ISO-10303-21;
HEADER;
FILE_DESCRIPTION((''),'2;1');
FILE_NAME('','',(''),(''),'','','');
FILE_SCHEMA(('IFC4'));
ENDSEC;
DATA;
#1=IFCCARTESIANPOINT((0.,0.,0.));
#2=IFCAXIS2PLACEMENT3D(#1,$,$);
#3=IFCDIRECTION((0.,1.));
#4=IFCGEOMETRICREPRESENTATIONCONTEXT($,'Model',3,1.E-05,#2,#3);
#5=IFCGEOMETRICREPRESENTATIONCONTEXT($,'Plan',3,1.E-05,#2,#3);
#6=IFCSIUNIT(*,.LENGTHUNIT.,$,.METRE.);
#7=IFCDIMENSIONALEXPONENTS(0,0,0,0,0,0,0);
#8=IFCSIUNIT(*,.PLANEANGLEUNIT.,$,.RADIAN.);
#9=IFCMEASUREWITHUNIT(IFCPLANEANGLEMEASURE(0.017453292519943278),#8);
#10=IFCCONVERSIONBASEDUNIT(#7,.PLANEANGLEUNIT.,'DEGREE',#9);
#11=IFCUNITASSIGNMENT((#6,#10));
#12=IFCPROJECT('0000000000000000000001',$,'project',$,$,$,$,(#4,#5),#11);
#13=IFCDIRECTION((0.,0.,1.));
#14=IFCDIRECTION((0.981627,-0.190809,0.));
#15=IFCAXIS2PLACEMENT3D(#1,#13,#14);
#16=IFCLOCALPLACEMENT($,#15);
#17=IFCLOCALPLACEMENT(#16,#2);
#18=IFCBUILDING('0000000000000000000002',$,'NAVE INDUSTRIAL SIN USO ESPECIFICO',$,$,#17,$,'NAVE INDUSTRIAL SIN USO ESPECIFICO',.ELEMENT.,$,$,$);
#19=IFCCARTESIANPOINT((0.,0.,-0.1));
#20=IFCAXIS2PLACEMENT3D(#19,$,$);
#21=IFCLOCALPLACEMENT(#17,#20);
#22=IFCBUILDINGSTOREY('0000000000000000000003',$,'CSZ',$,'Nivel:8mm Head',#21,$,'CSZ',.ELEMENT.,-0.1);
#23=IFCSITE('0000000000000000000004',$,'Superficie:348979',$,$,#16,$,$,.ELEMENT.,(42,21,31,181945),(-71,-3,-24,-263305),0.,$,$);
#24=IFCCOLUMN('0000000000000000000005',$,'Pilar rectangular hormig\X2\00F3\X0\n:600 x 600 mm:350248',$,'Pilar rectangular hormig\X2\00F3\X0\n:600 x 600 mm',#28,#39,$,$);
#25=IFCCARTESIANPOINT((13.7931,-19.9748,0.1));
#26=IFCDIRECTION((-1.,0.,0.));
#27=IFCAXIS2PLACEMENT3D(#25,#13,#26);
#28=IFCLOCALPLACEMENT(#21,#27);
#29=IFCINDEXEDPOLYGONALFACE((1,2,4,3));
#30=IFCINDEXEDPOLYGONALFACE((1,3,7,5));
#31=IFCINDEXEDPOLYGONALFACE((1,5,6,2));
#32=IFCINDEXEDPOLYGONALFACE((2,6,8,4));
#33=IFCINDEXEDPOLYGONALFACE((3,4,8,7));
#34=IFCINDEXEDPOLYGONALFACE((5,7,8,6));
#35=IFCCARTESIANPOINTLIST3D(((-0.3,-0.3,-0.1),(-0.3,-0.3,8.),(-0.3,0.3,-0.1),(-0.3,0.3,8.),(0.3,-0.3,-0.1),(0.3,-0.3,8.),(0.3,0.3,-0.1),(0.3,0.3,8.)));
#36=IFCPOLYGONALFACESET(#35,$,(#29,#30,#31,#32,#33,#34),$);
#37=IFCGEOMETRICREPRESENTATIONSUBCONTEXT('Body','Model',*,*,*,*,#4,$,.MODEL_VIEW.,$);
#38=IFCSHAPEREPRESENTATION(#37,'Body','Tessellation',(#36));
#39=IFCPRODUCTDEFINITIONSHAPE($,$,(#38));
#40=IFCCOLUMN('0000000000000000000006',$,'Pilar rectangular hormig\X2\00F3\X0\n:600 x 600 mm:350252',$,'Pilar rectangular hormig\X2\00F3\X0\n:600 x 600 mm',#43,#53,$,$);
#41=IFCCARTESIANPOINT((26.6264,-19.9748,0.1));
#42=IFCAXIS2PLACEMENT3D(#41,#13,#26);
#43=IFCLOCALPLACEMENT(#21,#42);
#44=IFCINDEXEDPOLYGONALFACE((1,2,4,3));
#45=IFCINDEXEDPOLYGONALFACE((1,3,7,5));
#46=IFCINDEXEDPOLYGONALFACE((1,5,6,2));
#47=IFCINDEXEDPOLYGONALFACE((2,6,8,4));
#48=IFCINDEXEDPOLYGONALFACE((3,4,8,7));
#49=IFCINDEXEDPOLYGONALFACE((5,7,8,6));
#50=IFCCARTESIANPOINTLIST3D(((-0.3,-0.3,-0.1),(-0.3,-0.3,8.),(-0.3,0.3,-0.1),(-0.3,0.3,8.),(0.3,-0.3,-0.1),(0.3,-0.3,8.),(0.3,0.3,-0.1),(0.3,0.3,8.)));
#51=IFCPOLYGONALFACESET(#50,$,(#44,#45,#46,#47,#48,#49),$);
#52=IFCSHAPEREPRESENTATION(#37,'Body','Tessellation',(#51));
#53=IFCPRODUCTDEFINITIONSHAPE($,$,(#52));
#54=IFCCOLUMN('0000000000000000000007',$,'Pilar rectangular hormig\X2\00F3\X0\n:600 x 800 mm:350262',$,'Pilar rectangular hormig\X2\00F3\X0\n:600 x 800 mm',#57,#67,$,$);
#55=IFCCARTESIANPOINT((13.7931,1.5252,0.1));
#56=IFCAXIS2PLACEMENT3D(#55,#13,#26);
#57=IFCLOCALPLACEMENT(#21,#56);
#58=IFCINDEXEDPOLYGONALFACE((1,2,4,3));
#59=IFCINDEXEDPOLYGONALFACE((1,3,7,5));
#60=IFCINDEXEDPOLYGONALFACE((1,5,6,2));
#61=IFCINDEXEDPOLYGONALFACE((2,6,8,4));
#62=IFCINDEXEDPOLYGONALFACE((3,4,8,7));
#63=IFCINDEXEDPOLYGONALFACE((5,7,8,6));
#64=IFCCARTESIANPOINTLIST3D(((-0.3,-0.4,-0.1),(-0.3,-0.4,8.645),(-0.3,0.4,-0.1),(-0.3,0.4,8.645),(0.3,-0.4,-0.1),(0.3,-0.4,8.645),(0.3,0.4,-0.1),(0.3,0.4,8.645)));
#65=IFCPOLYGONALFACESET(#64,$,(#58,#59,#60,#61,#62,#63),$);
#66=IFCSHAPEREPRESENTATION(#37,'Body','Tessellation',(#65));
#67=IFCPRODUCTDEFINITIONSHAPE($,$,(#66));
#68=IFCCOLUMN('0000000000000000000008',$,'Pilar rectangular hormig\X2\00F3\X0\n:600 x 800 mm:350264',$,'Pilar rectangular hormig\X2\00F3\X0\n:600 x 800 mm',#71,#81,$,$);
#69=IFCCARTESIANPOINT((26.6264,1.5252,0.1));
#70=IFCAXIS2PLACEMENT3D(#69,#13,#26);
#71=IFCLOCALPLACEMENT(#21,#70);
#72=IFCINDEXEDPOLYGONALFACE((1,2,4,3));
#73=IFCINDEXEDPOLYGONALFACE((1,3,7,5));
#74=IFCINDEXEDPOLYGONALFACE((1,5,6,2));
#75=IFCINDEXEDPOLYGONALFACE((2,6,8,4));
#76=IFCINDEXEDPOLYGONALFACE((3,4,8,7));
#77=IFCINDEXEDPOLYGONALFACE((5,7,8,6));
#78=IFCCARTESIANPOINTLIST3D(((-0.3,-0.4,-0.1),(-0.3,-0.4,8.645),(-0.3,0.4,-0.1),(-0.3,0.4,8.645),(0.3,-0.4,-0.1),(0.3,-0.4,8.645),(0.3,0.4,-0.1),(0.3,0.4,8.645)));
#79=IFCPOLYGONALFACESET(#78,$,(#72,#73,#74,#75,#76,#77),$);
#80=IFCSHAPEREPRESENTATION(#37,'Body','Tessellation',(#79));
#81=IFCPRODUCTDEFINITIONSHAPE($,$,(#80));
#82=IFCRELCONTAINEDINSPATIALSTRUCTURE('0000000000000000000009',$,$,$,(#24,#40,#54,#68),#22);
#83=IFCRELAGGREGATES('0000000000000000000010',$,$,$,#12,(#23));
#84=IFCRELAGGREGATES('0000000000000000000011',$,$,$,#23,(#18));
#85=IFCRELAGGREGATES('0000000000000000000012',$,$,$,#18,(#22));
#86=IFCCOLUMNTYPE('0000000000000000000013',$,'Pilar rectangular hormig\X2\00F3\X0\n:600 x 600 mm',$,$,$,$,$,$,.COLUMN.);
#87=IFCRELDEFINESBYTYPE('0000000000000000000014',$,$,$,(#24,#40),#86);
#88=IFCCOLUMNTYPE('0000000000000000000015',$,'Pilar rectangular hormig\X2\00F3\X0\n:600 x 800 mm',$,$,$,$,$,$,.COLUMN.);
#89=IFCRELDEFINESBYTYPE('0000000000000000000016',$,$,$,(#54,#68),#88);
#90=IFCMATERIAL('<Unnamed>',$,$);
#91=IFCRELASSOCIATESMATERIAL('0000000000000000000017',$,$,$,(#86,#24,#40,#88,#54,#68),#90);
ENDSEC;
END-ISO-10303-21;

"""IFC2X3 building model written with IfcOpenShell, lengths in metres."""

from ifc_helpers import new_model, entity, si_unit, converted_unit, direction, frame, origin, origin_2d_with_axis, place, context, subcontext, project, spatial, rectangle, extrude, source, transform, mapped, material, type_object, type_shapes, element, save


model = new_model("IFC2X3")

# Units and contexts
model_context = context("Model", 3, precision=1e-05, world=origin(), true_north=direction((0.0, 1.0)))
plan_context = context("Plan", 3, precision=1e-05, world=origin(), true_north=direction((0.0, 1.0)))
body_context = subcontext(model_context, "Body", "Model", "MODEL_VIEW")
ifc_project = project(units=[si_unit("LENGTHUNIT", "METRE"), converted_unit("PLANEANGLEUNIT", "DEGREE", entity("IfcPlaneAngleMeasure", 0.017453292519943278), si_unit("PLANEANGLEUNIT", "RADIAN"), dimensions=[0, 0, 0, 0, 0, 0, 0])], contexts=[model_context, plan_context])

# Site, building, storey
site_placement = place(None, frame((0.0, 0.0, 0.0), z_axis=(0.0, 0.0, 1.0), x_axis=(0.981627, -0.190809, 0.0)))
site = spatial("IfcSite", under=ifc_project, at=site_placement, Name="Superficie:348979", CompositionType="ELEMENT", RefLatitude=(42, 21, 31, 181945), RefLongitude=(-71, -3, -24, -263305), RefElevation=0.0)
building_placement = place(site_placement, origin())
building = spatial("IfcBuilding", under=site, at=building_placement, Name="NAVE INDUSTRIAL SIN USO ESPECIFICO", LongName="NAVE INDUSTRIAL SIN USO ESPECIFICO", CompositionType="ELEMENT")
storey_placement = place(building_placement, frame((0.0, 0.0, -0.1)))
storey = spatial("IfcBuildingStorey", under=building, at=storey_placement, Name="CSZ", ObjectType="Nivel:8mm Head", LongName="CSZ", CompositionType="ELEMENT", Elevation=-0.1)

# Columns
ifc_material_1 = material(Name="<Unnamed>")
column_type_1 = type_object("IfcColumnType", Name="Pilar rectangular hormigón:600 x 600 mm", PredefinedType="COLUMN", material=ifc_material_1)
shared_shape_1 = source(origin(), body_context, "Body", "SweptSolid", [
    extrude(rectangle(XDim=0.6, YDim=0.6, at=origin_2d_with_axis()), frame((0.0, 0.0, -0.1), z_axis=(0.0, 0.0, 1.0), x_axis=(-1.0, 0.0, 0.0)), (0.0, 0.0, 1.0), 8.1),
])
type_shapes(column_type_1, [shared_shape_1])
for number, where, z_axis, x_axis, name in (
    (1, (13.7931, -19.9748, 0.1), (0.0, 0.0, 1.0), (-1.0, 0.0, 0.0), "Pilar rectangular hormigón:600 x 600 mm:350248"),
    (2, (26.6264, -19.9748, 0.1), (0.0, 0.0, 1.0), (-1.0, 0.0, 0.0), "Pilar rectangular hormigón:600 x 600 mm:350252"),
):
    element("IfcColumn", number, at=place(storey_placement, frame(where, z_axis=z_axis, x_axis=x_axis)), inside=storey, type_object=column_type_1, material=ifc_material_1, Name=name, ObjectType="Pilar rectangular hormigón:600 x 600 mm", context=body_context, shape_type="MappedRepresentation", body=[
        mapped(shared_shape_1, transform((0.0, 0.0, 0.0), scale=1.0)),
    ])
column_type_2 = type_object("IfcColumnType", Name="Pilar rectangular hormigón:600 x 800 mm", PredefinedType="COLUMN", material=ifc_material_1)
shared_shape_2 = source(origin(), body_context, "Body", "SweptSolid", [
    extrude(rectangle(XDim=0.6, YDim=0.8, at=origin_2d_with_axis()), frame((0.0, 0.0, -0.1), z_axis=(0.0, 0.0, 1.0), x_axis=(-1.0, 0.0, 0.0)), (0.0, 0.0, 1.0), 8.745),
])
type_shapes(column_type_2, [shared_shape_2])
for number, where, z_axis, x_axis, name in (
    (3, (13.7931, 1.5252, 0.1), (0.0, 0.0, 1.0), (-1.0, 0.0, 0.0), "Pilar rectangular hormigón:600 x 800 mm:350262"),
    (4, (26.6264, 1.5252, 0.1), (0.0, 0.0, 1.0), (-1.0, 0.0, 0.0), "Pilar rectangular hormigón:600 x 800 mm:350264"),
):
    element("IfcColumn", number, at=place(storey_placement, frame(where, z_axis=z_axis, x_axis=x_axis)), inside=storey, type_object=column_type_2, material=ifc_material_1, Name=name, ObjectType="Pilar rectangular hormigón:600 x 800 mm", context=body_context, shape_type="MappedRepresentation", body=[
        mapped(shared_shape_2, transform((0.0, 0.0, 0.0), scale=1.0)),
    ])

save(model, "model.ifc")
